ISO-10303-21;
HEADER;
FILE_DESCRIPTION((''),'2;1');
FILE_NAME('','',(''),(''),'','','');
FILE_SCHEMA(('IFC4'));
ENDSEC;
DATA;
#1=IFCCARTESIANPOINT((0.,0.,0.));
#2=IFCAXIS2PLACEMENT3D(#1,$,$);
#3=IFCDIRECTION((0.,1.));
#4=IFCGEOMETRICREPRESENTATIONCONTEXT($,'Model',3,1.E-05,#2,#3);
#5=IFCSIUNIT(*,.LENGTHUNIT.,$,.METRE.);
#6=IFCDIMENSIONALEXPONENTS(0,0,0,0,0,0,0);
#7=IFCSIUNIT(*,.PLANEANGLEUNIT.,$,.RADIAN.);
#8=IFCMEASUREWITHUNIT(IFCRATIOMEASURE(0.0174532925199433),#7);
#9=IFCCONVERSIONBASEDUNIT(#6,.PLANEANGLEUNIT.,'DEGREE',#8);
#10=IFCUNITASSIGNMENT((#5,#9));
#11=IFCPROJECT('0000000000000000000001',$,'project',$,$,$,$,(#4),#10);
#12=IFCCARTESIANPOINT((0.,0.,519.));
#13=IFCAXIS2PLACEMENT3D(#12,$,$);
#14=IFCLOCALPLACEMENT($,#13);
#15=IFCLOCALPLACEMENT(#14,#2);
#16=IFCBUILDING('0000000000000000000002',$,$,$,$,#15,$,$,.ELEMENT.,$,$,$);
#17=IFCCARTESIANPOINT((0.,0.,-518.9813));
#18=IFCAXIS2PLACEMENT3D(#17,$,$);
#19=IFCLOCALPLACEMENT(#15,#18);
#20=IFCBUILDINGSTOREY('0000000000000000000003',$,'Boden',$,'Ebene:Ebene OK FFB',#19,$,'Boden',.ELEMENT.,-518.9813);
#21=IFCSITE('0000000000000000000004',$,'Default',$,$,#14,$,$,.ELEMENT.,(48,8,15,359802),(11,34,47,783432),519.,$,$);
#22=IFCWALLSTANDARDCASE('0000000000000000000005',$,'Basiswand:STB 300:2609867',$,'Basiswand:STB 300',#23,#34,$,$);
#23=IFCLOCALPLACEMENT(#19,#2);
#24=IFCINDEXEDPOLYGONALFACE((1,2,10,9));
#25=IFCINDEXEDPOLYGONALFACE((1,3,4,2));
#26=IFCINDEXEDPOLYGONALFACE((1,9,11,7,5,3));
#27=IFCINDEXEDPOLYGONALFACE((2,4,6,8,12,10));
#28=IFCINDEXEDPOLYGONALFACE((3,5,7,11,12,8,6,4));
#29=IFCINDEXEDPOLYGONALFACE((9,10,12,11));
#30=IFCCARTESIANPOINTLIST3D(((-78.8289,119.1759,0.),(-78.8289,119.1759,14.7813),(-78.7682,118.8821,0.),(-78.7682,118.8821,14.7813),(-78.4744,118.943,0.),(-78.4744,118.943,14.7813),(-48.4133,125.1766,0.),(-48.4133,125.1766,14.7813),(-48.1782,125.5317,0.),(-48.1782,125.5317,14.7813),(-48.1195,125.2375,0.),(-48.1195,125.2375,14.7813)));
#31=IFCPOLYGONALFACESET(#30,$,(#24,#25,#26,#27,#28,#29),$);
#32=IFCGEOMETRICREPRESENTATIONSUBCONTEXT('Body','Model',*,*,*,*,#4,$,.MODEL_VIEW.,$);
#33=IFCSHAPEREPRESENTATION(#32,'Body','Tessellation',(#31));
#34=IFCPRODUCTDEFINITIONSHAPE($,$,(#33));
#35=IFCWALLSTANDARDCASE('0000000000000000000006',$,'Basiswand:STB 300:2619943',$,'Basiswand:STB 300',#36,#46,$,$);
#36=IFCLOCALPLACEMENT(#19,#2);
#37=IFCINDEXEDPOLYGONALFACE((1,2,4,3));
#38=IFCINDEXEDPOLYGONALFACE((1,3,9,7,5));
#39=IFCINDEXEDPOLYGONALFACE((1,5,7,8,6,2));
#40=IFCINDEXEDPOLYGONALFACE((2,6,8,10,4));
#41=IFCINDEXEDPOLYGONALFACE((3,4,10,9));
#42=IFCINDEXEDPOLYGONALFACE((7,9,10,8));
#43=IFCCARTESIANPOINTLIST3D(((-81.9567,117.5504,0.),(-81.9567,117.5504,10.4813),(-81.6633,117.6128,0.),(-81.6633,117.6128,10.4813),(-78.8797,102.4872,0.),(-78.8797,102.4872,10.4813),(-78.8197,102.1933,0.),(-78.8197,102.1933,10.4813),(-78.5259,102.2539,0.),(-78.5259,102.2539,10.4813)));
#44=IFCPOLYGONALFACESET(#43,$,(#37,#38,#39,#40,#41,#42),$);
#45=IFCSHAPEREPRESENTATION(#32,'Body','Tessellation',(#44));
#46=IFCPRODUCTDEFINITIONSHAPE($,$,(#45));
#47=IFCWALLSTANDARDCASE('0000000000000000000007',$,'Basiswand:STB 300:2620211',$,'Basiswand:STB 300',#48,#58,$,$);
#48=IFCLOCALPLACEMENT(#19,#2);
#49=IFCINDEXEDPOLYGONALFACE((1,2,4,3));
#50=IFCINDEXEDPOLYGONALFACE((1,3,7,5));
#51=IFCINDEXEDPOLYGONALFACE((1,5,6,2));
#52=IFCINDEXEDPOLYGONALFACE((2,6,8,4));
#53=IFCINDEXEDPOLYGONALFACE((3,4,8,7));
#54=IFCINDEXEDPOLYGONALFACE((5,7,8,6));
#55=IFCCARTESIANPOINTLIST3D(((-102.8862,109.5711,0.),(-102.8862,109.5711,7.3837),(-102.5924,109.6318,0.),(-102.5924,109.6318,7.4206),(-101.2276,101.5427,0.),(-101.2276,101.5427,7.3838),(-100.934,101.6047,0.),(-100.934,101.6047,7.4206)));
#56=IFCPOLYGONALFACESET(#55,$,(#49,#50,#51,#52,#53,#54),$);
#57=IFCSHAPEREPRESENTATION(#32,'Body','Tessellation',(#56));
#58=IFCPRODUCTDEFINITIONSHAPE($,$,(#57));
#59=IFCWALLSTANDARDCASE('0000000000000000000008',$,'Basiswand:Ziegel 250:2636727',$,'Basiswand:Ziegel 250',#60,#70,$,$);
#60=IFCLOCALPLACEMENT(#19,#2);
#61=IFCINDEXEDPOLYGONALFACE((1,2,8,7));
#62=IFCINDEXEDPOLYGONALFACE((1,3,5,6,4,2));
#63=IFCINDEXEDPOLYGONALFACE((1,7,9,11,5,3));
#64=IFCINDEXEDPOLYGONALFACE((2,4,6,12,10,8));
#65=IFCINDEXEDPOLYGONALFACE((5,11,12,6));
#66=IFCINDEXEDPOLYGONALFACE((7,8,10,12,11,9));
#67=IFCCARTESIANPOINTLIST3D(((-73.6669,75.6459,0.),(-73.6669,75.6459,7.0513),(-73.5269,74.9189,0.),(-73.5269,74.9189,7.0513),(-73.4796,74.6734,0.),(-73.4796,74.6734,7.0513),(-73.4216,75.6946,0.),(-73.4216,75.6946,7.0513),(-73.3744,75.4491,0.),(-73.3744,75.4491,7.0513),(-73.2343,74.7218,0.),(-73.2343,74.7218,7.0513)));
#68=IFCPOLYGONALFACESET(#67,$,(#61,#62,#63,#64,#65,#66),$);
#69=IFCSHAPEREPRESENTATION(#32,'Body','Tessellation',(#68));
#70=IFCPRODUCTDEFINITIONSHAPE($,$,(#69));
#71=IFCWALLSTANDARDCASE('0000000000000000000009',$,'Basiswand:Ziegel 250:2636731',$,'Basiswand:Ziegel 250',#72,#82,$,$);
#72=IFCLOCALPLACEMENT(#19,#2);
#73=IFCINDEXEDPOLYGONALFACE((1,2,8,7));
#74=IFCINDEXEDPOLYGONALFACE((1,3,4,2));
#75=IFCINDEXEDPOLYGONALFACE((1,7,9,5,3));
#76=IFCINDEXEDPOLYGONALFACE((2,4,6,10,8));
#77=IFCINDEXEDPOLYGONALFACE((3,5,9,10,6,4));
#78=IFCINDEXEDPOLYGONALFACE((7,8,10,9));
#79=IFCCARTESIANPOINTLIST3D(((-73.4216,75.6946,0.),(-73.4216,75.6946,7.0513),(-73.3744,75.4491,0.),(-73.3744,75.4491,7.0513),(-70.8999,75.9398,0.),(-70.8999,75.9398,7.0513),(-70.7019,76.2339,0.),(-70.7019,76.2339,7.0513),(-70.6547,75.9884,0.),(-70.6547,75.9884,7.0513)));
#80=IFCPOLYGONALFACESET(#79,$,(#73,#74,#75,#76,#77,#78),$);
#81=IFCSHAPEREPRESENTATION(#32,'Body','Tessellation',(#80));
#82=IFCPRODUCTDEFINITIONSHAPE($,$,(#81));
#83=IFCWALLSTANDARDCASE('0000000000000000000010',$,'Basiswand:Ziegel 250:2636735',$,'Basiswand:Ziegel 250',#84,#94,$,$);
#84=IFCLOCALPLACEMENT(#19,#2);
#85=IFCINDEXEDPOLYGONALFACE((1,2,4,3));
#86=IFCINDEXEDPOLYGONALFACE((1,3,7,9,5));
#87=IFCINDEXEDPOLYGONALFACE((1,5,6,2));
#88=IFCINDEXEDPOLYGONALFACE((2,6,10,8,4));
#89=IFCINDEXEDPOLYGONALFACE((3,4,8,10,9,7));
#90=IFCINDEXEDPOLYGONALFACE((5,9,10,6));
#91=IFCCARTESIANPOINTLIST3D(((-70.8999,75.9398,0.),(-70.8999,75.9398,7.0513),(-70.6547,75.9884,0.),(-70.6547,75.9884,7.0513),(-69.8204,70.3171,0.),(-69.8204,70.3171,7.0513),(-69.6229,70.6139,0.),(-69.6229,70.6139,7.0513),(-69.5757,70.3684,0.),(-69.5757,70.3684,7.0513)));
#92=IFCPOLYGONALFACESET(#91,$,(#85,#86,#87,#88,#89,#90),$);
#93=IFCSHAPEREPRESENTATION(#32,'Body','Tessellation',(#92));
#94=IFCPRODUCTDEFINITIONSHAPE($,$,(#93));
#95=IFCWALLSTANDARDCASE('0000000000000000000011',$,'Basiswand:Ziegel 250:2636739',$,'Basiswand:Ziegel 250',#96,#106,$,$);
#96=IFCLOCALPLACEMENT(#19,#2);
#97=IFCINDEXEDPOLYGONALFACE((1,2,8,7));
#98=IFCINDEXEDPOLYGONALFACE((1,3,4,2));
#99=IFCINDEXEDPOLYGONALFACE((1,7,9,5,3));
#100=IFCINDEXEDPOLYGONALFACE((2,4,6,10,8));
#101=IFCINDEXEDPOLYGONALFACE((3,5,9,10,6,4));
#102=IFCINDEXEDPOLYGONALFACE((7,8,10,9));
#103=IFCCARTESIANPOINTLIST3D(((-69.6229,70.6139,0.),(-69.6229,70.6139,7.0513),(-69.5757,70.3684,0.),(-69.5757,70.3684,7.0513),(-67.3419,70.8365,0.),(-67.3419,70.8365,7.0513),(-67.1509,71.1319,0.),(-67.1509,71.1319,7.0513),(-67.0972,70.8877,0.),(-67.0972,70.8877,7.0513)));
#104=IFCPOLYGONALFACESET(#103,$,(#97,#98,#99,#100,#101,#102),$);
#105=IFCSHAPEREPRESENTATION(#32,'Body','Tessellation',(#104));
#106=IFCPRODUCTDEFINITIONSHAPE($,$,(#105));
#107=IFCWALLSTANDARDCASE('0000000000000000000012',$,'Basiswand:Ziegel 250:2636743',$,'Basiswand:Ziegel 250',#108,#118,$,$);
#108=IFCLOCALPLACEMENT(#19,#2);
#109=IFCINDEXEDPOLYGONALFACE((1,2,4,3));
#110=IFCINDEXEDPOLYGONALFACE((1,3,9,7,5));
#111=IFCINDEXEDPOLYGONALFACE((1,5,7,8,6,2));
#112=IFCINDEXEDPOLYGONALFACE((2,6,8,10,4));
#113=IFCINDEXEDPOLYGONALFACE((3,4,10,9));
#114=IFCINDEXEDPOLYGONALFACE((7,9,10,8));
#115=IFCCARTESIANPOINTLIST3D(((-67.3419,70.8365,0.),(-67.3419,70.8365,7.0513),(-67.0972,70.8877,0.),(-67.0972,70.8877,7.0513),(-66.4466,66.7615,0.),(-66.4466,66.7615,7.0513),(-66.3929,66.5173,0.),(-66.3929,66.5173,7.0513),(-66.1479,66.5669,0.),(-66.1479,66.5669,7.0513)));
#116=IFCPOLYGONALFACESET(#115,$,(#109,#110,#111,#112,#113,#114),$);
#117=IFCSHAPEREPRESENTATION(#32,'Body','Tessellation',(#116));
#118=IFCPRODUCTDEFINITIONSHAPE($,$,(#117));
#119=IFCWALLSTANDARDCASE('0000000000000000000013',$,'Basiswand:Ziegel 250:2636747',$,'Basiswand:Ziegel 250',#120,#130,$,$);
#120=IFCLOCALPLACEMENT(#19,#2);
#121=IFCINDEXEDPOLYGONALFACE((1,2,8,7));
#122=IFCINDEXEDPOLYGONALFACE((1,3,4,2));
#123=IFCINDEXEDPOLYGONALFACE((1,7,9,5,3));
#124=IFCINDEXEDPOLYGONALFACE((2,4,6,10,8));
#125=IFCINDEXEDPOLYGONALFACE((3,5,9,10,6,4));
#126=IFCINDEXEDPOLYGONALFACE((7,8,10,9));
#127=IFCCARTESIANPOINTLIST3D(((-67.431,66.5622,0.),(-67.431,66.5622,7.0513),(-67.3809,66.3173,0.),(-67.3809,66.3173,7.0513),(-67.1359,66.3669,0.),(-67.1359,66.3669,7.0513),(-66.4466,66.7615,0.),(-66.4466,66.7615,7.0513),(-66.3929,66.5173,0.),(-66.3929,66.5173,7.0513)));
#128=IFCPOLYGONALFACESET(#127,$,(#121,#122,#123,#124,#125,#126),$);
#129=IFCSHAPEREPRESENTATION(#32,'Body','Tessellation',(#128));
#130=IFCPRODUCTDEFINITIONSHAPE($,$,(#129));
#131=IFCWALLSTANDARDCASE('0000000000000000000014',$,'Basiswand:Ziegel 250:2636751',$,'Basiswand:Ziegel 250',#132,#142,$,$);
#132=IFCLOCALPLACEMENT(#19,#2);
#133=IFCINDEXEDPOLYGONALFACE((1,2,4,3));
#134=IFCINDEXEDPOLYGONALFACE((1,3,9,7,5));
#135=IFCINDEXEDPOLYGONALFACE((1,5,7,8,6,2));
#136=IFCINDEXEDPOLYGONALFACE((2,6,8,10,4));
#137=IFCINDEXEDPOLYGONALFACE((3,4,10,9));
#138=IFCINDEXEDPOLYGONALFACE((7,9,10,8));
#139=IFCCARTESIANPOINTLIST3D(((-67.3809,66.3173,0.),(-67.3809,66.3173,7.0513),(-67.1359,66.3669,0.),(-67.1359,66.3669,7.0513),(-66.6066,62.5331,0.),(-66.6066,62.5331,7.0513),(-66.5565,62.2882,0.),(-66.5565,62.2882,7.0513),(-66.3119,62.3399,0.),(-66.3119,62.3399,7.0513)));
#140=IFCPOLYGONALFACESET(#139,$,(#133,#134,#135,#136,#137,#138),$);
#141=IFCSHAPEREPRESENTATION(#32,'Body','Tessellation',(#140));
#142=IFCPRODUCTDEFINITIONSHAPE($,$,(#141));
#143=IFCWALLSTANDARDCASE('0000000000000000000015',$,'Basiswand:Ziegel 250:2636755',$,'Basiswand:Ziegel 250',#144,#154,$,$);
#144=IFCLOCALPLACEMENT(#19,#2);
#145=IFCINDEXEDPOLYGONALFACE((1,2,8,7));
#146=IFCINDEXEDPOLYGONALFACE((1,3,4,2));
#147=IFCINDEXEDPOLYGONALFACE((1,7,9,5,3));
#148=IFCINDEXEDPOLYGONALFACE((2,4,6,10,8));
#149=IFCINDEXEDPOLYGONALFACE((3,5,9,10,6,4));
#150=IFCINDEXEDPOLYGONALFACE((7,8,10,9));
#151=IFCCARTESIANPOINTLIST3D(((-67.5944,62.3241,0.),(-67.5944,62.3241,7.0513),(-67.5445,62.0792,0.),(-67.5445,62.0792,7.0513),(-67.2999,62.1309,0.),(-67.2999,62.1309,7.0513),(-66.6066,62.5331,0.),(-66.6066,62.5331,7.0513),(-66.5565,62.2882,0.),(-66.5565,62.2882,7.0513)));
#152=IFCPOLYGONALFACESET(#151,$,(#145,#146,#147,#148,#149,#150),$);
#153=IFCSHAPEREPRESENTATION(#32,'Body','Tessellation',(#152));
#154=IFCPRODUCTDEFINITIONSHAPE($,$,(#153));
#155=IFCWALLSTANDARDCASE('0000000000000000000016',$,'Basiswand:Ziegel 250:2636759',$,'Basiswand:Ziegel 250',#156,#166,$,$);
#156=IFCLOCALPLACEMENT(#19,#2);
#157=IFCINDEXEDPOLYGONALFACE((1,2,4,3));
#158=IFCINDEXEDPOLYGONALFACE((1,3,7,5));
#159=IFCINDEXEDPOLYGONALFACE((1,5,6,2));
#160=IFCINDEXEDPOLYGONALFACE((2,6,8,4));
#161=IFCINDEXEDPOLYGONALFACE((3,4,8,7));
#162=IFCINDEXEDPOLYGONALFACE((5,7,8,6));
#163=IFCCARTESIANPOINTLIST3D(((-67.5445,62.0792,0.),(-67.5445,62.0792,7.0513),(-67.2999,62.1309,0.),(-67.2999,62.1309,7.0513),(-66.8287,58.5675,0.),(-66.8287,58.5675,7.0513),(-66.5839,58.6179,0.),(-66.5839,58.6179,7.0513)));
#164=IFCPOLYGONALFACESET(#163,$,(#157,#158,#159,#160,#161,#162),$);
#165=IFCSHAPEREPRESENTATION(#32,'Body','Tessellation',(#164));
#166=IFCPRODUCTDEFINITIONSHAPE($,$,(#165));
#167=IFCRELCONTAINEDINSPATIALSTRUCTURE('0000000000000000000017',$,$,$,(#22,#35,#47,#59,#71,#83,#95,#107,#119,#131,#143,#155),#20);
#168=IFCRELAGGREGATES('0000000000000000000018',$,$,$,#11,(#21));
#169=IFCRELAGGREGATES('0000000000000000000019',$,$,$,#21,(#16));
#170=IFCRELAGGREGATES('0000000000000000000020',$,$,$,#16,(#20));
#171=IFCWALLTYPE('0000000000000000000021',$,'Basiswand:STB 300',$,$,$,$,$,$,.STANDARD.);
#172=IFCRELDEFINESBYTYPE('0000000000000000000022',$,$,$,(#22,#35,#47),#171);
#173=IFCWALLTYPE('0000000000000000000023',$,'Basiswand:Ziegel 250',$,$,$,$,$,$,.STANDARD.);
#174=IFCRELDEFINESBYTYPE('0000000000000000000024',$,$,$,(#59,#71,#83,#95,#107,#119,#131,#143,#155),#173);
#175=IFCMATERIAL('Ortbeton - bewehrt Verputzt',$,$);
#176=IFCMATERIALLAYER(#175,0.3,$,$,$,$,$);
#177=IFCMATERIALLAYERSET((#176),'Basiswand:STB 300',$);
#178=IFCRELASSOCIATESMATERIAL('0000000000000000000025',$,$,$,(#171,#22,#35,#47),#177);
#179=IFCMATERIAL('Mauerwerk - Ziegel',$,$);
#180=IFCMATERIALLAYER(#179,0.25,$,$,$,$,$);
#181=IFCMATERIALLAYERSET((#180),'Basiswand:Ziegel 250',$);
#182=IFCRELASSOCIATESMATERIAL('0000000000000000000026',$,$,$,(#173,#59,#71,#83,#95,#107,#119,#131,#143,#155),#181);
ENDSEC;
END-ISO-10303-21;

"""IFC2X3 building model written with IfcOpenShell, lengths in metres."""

from ifc_helpers import new_model, entity, si_unit, converted_unit, direction, frame, origin, place, context, subcontext, project, spatial, polyline, outline, extrude, clip, bounded_halfspace, material, layer, layer_set, layer_usage, type_object, element, save


model = new_model("IFC2X3")

# Units and contexts
model_context = context("Model", 3, precision=1e-05, world=origin(), true_north=direction((0.0, 1.0)))
body_context = subcontext(model_context, "Body", "Model", "MODEL_VIEW")
ifc_project = project(units=[si_unit("LENGTHUNIT", "METRE"), converted_unit("PLANEANGLEUNIT", "DEGREE", entity("IfcRatioMeasure", 0.0174532925199433), si_unit("PLANEANGLEUNIT", "RADIAN"), dimensions=[0, 0, 0, 0, 0, 0, 0])], contexts=[model_context])

# Site, building, storey
site_placement = place(None, frame((0.0, 0.0, 519.0)))
site = spatial("IfcSite", under=ifc_project, at=site_placement, Name="Default", CompositionType="ELEMENT", RefLatitude=(48, 8, 15, 359802), RefLongitude=(11, 34, 47, 783432), RefElevation=519.0)
building_placement = place(site_placement, origin())
building = spatial("IfcBuilding", under=site, at=building_placement, CompositionType="ELEMENT")
storey_placement = place(building_placement, frame((0.0, 0.0, -518.9813)))
storey = spatial("IfcBuildingStorey", under=building, at=storey_placement, Name="Boden", ObjectType="Ebene:Ebene OK FFB", LongName="Boden", CompositionType="ELEMENT", Elevation=-518.9813)

# Walls
ifc_material_1 = material(Name="Ortbeton - bewehrt Verputzt")
ifc_layer_1 = layer(ifc_material_1, 0.3)
ifc_layer_set_1 = layer_set([ifc_layer_1], Name="Basiswand:STB 300")
ifc_layer_usage_1 = layer_usage(ifc_layer_set_1, "AXIS2", "NEGATIVE", 0.15)
wall_type_1 = type_object("IfcWallType", Name="Basiswand:STB 300", PredefinedType="STANDARD", material=ifc_layer_set_1)
wall_1_placement = place(storey_placement, frame((-78.7986, 119.029, 0.0), z_axis=(0.0, 0.0, 1.0), x_axis=(0.97917, 0.203043, 0.0)))
element("IfcWallStandardCase", 1, at=wall_1_placement, inside=storey, type_object=wall_type_1, material=ifc_layer_usage_1, Name="Basiswand:STB 300:2609867", ObjectType="Basiswand:STB 300", context=body_context, shape_type="SweptSolid", body=[
    extrude(outline(polyline([(31.3006, -0.15), (31.3029, 0.15), (0.0002, 0.15), (0.0, -0.15), (0.3, -0.15), (31.0006, -0.15), (31.3006, -0.15)])), origin(), (0.0, 0.0, 1.0), 14.7813),
])
ifc_layer_usage_2 = layer_usage(ifc_layer_set_1, "AXIS2", "NEGATIVE", 0.15)
wall_2_placement = place(storey_placement, frame((-81.8102, 117.5828, 0.0), z_axis=(0.0, 0.0, 1.0), x_axis=(0.200141, -0.979767, 0.0)))
element("IfcWallStandardCase", 2, at=wall_2_placement, inside=storey, type_object=wall_type_1, material=ifc_layer_usage_2, Name="Basiswand:STB 300:2619943", ObjectType="Basiswand:STB 300", context=body_context, shape_type="SweptSolid", body=[
    extrude(outline(polyline([(15.6766, -0.15), (15.676, 0.15), (0.0, 0.15), (0.0024, -0.15), (15.3766, -0.15), (15.6766, -0.15)])), origin(), (0.0, 0.0, 1.0), 10.4813),
])
ifc_layer_usage_3 = layer_usage(ifc_layer_set_1, "AXIS2", "NEGATIVE", 0.15)
wall_3_placement = place(storey_placement, frame((-101.0807, 101.5731, 0.0), z_axis=(0.0, 0.0, 1.0), x_axis=(-0.20232, 0.979319, 0.0)))
element("IfcWallStandardCase", 3, at=wall_3_placement, inside=storey, type_object=wall_type_1, material=ifc_layer_usage_3, Name="Basiswand:STB 300:2620211", ObjectType="Basiswand:STB 300", context=body_context, shape_type="Clipping", body=[
    clip(extrude(outline(polyline([(8.1979, -0.15), (8.1979, 0.15), (0.0, 0.15), (0.0013, -0.15), (8.1979, -0.15)])), origin(), (0.0, 0.0, 1.0), 7.4206), bounded_halfspace(frame((0.0013, -0.15, 7.4206), z_axis=(-0.000002, -0.121869, -0.992546), x_axis=(1.0, -0.00002, 0.0)), True, frame((0.0013, -0.15, 7.4206), z_axis=(-0.000002, -0.121869, -0.992546), x_axis=(1.0, -0.00002, 0.0)), polyline([(0.0, 0.0), (-0.0013, -0.3023), (8.1966, -0.3024), (8.1966, -0.0002), (0.0, 0.0)]))),
])
ifc_material_2 = material(Name="Mauerwerk - Ziegel")
ifc_layer_2 = layer(ifc_material_2, 0.25)
ifc_layer_set_2 = layer_set([ifc_layer_2], Name="Basiswand:Ziegel 250")
ifc_layer_usage_4 = layer_usage(ifc_layer_set_2, "AXIS2", "NEGATIVE", 0.125)
wall_type_2 = type_object("IfcWallType", Name="Basiswand:Ziegel 250", PredefinedType="STANDARD", material=ifc_layer_set_2)
wall_4_placement = place(storey_placement, frame((-73.3568, 74.6971, 0.0), z_axis=(0.0, 0.0, 1.0), x_axis=(-0.189098, 0.981958, 0.0)))
element("IfcWallStandardCase", 4, at=wall_4_placement, inside=storey, type_object=wall_type_2, material=ifc_layer_usage_4, Name="Basiswand:Ziegel 250:2636727", ObjectType="Basiswand:Ziegel 250", context=body_context, shape_type="SweptSolid", body=[
    extrude(outline(polyline([(0.9917, -0.125), (0.9904, 0.125), (0.25, 0.125), (0.0, 0.125), (0.0011, -0.125), (0.7417, -0.125), (0.9917, -0.125)])), origin(), (0.0, 0.0, 1.0), 7.0513),
])
ifc_layer_usage_5 = layer_usage(ifc_layer_set_2, "AXIS2", "NEGATIVE", 0.125)
wall_5_placement = place(storey_placement, frame((-73.3987, 75.5717, 0.0), z_axis=(0.0, 0.0, 1.0), x_axis=(0.980897, 0.194525, 0.0)))
element("IfcWallStandardCase", 5, at=wall_5_placement, inside=storey, type_object=wall_type_2, material=ifc_layer_usage_5, Name="Basiswand:Ziegel 250:2636731", ObjectType="Basiswand:Ziegel 250", context=body_context, shape_type="SweptSolid", body=[
    extrude(outline(polyline([(2.7726, -0.125), (2.7741, 0.125), (0.0014, 0.125), (0.0, -0.125), (2.5226, -0.125), (2.7726, -0.125)])), origin(), (0.0, 0.0, 1.0), 7.0513),
])
ifc_layer_usage_6 = layer_usage(ifc_layer_set_2, "AXIS2", "NEGATIVE", 0.125)
wall_6_placement = place(storey_placement, frame((-70.7775, 75.9648, 0.0), z_axis=(0.0, 0.0, 1.0), x_axis=(0.188549, -0.982064, 0.0)))
element("IfcWallStandardCase", 6, at=wall_6_placement, inside=storey, type_object=wall_type_2, material=ifc_layer_usage_6, Name="Basiswand:Ziegel 250:2636735", ObjectType="Basiswand:Ziegel 250", context=body_context, shape_type="SweptSolid", body=[
    extrude(outline(polyline([(5.7269, -0.125), (5.7227, 0.125), (5.4726, 0.125), (0.0, 0.125), (0.0015, -0.125), (5.7269, -0.125)])), origin(), (0.0, 0.0, 1.0), 7.0513),
])
ifc_layer_usage_7 = layer_usage(ifc_layer_set_2, "AXIS2", "NEGATIVE", 0.125)
wall_7_placement = place(storey_placement, frame((-69.6014, 70.4907, 0.0), z_axis=(0.0, 0.0, 1.0), x_axis=(0.978743, 0.205093, 0.0)))
element("IfcWallStandardCase", 7, at=wall_7_placement, inside=storey, type_object=wall_type_2, material=ifc_layer_usage_7, Name="Basiswand:Ziegel 250:2636739", ObjectType="Basiswand:Ziegel 250", context=body_context, shape_type="SweptSolid", body=[
    extrude(outline(polyline([(2.5323, -0.125), (2.5299, 0.125), (0.0042, 0.125), (0.0, -0.125), (2.2823, -0.125), (2.5323, -0.125)])), origin(), (0.0, 0.0, 1.0), 7.0513),
])
ifc_layer_usage_8 = layer_usage(ifc_layer_set_2, "AXIS2", "NEGATIVE", 0.125)
wall_8_placement = place(storey_placement, frame((-67.2198, 70.8633, 0.0), z_axis=(0.0, 0.0, 1.0), x_axis=(0.214596, -0.976703, 0.0)))
element("IfcWallStandardCase", 8, at=wall_8_placement, inside=storey, type_object=wall_type_2, material=ifc_layer_usage_8, Name="Basiswand:Ziegel 250:2636743", ObjectType="Basiswand:Ziegel 250", context=body_context, shape_type="SweptSolid", body=[
    extrude(outline(polyline([(4.4222, -0.125), (4.4263, 0.125), (0.0024, 0.125), (0.0, -0.125), (4.1721, -0.125), (4.4222, -0.125)])), origin(), (0.0, 0.0, 1.0), 7.0513),
])
ifc_layer_usage_9 = layer_usage(ifc_layer_set_2, "AXIS2", "NEGATIVE", 0.125)
wall_9_placement = place(storey_placement, frame((-66.4177, 66.6398, 0.0), z_axis=(0.0, 0.0, 1.0), x_axis=(-0.98012, -0.198405, 0.0)))
element("IfcWallStandardCase", 9, at=wall_9_placement, inside=storey, type_object=wall_type_2, material=ifc_layer_usage_9, Name="Basiswand:Ziegel 250:2636747", ObjectType="Basiswand:Ziegel 250", context=body_context, shape_type="SweptSolid", body=[
    extrude(outline(polyline([(1.0085, -0.125), (1.008, 0.125), (0.758, 0.125), (0.0, 0.125), (0.0041, -0.125), (1.0085, -0.125)])), origin(), (0.0, 0.0, 1.0), 7.0513),
])
ifc_layer_usage_10 = layer_usage(ifc_layer_set_2, "AXIS2", "NEGATIVE", 0.125)
wall_10_placement = place(storey_placement, frame((-67.2584, 66.3424, 0.0), z_axis=(0.0, 0.0, 1.0), x_axis=(0.200465, -0.979701, 0.0)))
element("IfcWallStandardCase", 10, at=wall_10_placement, inside=storey, type_object=wall_type_2, material=ifc_layer_usage_10, Name="Basiswand:Ziegel 250:2636751", ObjectType="Basiswand:Ziegel 250", context=body_context, shape_type="SweptSolid", body=[
    extrude(outline(polyline([(4.1126, -0.125), (4.111, 0.125), (0.0005, 0.125), (0.0, -0.125), (3.8626, -0.125), (4.1126, -0.125)])), origin(), (0.0, 0.0, 1.0), 7.0513),
])
ifc_layer_usage_11 = layer_usage(ifc_layer_set_2, "AXIS2", "NEGATIVE", 0.125)
wall_11_placement = place(storey_placement, frame((-66.5807, 62.4108, 0.0), z_axis=(0.0, 0.0, 1.0), x_axis=(-0.97835, -0.206959, 0.0)))
element("IfcWallStandardCase", 11, at=wall_11_placement, inside=storey, type_object=wall_type_2, material=ifc_layer_usage_11, Name="Basiswand:Ziegel 250:2636755", ObjectType="Basiswand:Ziegel 250", context=body_context, shape_type="SweptSolid", body=[
    extrude(outline(polyline([(1.0097, -0.125), (1.0115, 0.125), (0.7615, 0.125), (0.0017, 0.125), (0.0, -0.125), (1.0097, -0.125)])), origin(), (0.0, 0.0, 1.0), 7.0513),
])
ifc_layer_usage_12 = layer_usage(ifc_layer_set_2, "AXIS2", "NEGATIVE", 0.125)
wall_12_placement = place(storey_placement, frame((-67.4223, 62.106, 0.0), z_axis=(0.0, 0.0, 1.0), x_axis=(0.199709, -0.979855, 0.0)))
element("IfcWallStandardCase", 12, at=wall_12_placement, inside=storey, type_object=wall_type_2, material=ifc_layer_usage_12, Name="Basiswand:Ziegel 250:2636759", ObjectType="Basiswand:Ziegel 250", context=body_context, shape_type="SweptSolid", body=[
    extrude(outline(polyline([(3.5858, -0.125), (3.5852, 0.125), (0.0, 0.125), (0.0019, -0.125), (3.5858, -0.125)])), origin(), (0.0, 0.0, 1.0), 7.0513),
])

save(model, "model.ifc")
